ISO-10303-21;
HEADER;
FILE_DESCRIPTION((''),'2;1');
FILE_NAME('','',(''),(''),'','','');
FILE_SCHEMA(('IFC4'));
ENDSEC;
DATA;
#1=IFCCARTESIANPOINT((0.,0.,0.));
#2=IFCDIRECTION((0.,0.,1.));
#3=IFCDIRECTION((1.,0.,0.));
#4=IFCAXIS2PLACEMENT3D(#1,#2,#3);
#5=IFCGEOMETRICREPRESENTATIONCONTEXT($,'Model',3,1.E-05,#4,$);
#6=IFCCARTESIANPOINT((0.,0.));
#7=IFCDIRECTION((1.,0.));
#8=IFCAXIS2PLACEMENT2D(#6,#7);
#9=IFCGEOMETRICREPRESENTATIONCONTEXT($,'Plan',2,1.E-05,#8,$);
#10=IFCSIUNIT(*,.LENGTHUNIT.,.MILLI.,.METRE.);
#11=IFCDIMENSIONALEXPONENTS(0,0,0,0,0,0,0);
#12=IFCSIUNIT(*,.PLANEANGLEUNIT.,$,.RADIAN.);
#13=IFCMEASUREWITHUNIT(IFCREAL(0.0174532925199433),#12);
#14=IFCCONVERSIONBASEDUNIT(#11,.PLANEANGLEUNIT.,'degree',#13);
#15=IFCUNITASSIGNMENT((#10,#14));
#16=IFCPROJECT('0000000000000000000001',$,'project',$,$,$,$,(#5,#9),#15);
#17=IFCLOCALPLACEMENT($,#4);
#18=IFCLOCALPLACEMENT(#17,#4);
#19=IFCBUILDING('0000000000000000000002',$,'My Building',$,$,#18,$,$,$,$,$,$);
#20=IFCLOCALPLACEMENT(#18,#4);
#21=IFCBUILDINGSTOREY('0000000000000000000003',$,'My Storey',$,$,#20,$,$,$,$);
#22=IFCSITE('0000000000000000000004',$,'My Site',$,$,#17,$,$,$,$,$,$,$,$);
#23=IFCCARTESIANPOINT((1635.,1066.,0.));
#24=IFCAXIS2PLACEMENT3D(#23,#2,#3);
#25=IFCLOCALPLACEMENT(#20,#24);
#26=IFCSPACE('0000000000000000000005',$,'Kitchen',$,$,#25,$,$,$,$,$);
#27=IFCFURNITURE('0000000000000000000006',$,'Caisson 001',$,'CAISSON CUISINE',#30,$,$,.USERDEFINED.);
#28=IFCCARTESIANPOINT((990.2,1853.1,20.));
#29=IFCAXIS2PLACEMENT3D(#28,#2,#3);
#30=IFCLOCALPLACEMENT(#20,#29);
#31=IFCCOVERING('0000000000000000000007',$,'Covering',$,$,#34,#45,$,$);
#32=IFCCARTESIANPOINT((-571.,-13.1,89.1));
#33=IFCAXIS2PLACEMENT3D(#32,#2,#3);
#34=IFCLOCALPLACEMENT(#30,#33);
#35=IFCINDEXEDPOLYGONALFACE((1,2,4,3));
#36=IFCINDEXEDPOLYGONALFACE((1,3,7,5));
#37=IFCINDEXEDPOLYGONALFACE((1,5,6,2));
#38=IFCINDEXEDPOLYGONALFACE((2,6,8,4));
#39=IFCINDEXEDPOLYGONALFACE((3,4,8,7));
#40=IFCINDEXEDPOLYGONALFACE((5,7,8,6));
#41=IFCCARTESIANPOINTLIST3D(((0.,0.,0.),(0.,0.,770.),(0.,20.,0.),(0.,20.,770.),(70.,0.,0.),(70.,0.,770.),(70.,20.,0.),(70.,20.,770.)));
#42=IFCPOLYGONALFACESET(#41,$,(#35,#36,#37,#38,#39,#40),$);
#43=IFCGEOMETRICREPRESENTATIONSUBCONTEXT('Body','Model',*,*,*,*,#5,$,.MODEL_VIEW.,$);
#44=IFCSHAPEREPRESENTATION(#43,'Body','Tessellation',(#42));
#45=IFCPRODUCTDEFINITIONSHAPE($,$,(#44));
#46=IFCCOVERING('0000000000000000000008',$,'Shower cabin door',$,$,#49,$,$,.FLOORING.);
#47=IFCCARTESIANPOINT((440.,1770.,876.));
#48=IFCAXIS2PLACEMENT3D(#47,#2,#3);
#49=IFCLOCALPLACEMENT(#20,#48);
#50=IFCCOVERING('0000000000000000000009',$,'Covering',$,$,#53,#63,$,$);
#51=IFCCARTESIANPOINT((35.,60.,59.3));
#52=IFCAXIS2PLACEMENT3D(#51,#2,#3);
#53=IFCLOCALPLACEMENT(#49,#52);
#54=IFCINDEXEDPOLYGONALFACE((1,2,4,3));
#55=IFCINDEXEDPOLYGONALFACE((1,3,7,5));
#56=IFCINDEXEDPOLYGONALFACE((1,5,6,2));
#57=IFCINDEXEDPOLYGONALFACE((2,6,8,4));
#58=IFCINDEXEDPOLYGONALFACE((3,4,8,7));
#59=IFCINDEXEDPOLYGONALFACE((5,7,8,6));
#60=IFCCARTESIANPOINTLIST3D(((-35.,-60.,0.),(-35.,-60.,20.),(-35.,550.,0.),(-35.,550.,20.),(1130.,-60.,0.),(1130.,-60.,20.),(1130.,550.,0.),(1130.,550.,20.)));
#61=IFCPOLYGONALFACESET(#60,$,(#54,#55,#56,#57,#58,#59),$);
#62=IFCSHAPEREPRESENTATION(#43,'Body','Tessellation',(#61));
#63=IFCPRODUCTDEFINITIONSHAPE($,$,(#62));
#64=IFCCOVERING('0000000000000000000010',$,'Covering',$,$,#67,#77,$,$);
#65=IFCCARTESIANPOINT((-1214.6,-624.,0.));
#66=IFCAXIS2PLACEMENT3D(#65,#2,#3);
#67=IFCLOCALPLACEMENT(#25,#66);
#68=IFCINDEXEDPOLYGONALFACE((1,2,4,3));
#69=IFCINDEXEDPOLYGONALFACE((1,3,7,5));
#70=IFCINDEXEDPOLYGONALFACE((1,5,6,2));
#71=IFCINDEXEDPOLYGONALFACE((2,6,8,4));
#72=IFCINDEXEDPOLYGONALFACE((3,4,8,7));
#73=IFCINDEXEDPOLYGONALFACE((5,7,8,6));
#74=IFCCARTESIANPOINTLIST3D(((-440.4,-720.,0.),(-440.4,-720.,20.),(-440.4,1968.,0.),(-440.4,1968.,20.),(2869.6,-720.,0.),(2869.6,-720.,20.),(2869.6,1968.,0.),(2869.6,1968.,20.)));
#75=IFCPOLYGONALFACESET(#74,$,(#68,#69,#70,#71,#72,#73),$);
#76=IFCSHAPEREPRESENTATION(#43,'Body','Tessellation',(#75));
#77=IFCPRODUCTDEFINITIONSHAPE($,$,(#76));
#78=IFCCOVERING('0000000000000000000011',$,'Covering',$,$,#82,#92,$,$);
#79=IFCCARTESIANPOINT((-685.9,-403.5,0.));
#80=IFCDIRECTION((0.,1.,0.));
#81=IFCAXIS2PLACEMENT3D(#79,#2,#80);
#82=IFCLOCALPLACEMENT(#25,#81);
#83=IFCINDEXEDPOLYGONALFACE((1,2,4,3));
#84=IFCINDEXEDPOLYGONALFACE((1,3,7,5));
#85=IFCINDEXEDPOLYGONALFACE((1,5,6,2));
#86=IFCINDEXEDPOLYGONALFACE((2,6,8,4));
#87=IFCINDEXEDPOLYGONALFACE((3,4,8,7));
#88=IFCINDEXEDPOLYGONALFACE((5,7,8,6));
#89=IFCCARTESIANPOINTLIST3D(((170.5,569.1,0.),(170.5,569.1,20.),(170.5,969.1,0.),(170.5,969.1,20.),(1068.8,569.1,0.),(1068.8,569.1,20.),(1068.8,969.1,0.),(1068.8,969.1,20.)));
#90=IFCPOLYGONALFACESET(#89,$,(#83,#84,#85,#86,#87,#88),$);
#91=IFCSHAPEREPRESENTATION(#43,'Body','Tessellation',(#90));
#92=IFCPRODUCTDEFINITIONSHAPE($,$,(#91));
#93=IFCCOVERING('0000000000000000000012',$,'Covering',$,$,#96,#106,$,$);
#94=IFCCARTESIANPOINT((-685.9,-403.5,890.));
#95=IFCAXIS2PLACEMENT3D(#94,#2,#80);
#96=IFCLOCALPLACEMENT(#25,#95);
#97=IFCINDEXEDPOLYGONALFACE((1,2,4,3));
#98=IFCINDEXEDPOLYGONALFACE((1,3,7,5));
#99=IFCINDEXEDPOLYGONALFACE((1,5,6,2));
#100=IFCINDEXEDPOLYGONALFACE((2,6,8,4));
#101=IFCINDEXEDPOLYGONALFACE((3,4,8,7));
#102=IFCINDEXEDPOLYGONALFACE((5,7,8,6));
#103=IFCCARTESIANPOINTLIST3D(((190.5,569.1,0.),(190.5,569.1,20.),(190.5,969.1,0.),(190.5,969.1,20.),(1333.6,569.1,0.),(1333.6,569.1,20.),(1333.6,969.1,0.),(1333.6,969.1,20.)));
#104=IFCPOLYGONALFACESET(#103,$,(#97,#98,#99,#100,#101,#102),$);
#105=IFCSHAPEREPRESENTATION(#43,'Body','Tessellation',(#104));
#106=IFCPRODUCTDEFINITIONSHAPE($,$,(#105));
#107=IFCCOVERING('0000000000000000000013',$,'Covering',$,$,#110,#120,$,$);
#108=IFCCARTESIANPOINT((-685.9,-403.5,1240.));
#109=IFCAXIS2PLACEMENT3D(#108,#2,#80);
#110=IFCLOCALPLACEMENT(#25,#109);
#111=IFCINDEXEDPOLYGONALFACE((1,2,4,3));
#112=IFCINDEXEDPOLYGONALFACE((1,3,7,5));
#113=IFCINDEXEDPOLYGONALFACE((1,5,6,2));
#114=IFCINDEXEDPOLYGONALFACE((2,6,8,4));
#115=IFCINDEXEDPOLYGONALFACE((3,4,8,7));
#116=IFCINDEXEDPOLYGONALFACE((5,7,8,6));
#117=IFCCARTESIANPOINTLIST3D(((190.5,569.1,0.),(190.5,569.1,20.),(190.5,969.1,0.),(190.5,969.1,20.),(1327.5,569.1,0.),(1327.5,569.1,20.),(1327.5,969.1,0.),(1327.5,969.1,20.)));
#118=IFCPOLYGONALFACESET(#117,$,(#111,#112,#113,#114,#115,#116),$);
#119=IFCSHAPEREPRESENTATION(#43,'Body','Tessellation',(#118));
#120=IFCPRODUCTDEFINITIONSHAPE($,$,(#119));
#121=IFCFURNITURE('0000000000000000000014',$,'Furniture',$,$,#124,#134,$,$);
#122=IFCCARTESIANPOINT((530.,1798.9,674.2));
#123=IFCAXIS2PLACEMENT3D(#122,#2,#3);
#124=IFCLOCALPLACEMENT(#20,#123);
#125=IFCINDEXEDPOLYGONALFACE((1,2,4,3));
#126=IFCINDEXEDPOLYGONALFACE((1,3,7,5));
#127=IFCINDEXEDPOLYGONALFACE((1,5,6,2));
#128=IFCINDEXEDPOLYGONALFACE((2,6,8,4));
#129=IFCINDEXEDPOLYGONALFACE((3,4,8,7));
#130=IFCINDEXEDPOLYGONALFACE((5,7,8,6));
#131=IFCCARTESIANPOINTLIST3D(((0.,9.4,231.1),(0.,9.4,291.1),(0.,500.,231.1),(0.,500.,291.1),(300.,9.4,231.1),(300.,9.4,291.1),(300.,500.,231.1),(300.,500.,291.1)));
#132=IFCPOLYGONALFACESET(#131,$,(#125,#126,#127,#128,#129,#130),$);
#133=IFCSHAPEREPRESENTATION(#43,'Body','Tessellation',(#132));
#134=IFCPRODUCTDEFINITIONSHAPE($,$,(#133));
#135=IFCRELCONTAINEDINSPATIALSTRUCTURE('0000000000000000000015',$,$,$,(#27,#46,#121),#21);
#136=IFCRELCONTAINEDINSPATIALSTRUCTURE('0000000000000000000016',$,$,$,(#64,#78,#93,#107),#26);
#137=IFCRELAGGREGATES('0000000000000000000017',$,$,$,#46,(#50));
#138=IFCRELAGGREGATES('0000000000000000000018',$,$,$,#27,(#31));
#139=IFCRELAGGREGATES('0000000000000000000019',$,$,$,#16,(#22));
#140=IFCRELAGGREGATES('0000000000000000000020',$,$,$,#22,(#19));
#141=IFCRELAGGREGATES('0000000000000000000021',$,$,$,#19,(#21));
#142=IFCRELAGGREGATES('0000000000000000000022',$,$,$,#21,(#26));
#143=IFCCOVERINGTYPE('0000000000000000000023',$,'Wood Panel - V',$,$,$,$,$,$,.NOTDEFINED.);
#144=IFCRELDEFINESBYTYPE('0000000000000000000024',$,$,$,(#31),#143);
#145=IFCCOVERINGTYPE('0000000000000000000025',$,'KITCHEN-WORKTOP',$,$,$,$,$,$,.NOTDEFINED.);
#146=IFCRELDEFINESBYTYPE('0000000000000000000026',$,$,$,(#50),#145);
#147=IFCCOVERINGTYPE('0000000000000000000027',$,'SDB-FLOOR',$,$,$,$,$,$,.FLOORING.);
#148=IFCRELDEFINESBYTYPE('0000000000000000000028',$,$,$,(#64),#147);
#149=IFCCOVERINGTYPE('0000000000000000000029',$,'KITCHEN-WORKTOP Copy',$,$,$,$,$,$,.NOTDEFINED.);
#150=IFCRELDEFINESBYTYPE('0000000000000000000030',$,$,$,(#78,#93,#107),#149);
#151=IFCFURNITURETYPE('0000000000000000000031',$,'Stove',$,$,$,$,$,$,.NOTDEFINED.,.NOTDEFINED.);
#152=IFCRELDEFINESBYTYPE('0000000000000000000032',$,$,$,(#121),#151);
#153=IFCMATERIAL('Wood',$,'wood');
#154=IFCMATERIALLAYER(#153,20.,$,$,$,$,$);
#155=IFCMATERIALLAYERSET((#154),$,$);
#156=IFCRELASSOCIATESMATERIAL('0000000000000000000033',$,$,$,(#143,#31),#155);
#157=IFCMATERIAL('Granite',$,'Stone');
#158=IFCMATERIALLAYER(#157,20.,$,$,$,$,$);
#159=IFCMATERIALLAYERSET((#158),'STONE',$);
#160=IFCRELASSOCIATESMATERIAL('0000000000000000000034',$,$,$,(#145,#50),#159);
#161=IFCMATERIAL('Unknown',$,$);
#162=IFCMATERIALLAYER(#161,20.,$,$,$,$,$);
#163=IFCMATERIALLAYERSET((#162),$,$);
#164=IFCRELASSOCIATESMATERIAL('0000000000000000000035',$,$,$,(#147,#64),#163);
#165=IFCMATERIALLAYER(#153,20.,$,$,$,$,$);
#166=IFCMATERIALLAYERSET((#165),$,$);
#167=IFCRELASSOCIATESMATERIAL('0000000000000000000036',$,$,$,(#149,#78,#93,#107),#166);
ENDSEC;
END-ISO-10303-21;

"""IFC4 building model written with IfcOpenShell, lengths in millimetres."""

from ifc_helpers import new_model, entity, si_unit, converted_unit, frame, origin_with_axes, origin_2d_with_axis, place, context, subcontext, project, spatial, line, indexed_curve, outline, extrude, source, transform, mapped, material, layer, layer_set, layer_usage, type_object, type_shapes, element, aggregate, save


model = new_model("IFC4")

# Units and contexts
model_context = context("Model", 3, precision=1e-05, world=origin_with_axes())
plan_context = context("Plan", 2, precision=1e-05, world=origin_2d_with_axis())
body_context = subcontext(model_context, "Body", "Model", "MODEL_VIEW")
ifc_project = project(units=[si_unit("LENGTHUNIT", "METRE", prefix="MILLI"), converted_unit("PLANEANGLEUNIT", "degree", entity("IfcReal", 0.0174532925199433), si_unit("PLANEANGLEUNIT", "RADIAN"), dimensions=[0, 0, 0, 0, 0, 0, 0])], contexts=[model_context, plan_context])

# Site, building, storey, space
site_placement = place(None, origin_with_axes())
site = spatial("IfcSite", under=ifc_project, at=site_placement, Name="My Site")
building_placement = place(site_placement, origin_with_axes())
building = spatial("IfcBuilding", under=site, at=building_placement, Name="My Building")
storey_placement = place(building_placement, origin_with_axes())
storey = spatial("IfcBuildingStorey", under=building, at=storey_placement, Name="My Storey")
space_1_placement = place(storey_placement, frame((1635.0, 1066.0, 0.0), z_axis=(0.0, 0.0, 1.0), x_axis=(1.0, 0.0, 0.0)))
space_1 = spatial("IfcSpace", under=storey, at=space_1_placement, Name="Kitchen")

# Shared definitions
ifc_material_1 = material(Name="Unknown")

# Furniture
furniture_1_placement = place(storey_placement, frame((990.2, 1853.1, 20.0), z_axis=(0.0, 0.0, 1.0), x_axis=(1.0, 0.0, 0.0)))
furniture_1 = element("IfcFurniture", 1, at=furniture_1_placement, inside=storey, Name="Caisson 001", ObjectType="CAISSON CUISINE", PredefinedType="USERDEFINED")

# Shared definitions
ifc_material_2 = material(Name="Wood", Category="wood")
ifc_layer_1 = layer(ifc_material_2, 20.0)
ifc_layer_set_1 = layer_set([ifc_layer_1])
covering_type_1 = type_object("IfcCoveringType", Name="Wood Panel - V", PredefinedType="NOTDEFINED", material=ifc_layer_set_1)

# Covering
ifc_layer_usage_1 = layer_usage(ifc_layer_set_1, "AXIS2", "POSITIVE", 0.0)
covering_1_placement = place(furniture_1_placement, frame((-571.0, -13.1, 89.1), z_axis=(0.0, 0.0, 1.0), x_axis=(1.0, 0.0, 0.0)))
covering_1 = element("IfcCovering", 2, at=covering_1_placement, type_object=covering_type_1, material=ifc_layer_usage_1, Name="Covering", context=body_context, shape_type="SweptSolid", body=[
    extrude(outline(indexed_curve([(0.0, 0.0), (0.0, 20.0), (70.0, 20.0), (70.0, 0.0), (0.0, 0.0)], self_intersect=False)), origin_with_axes(), (0.0, 0.0, 1.0), 770.0),
])

# Coverings
covering_2_placement = place(storey_placement, frame((440.0, 1770.0, 876.0), z_axis=(0.0, 0.0, 1.0), x_axis=(1.0, 0.0, 0.0)))
covering_2 = element("IfcCovering", 3, at=covering_2_placement, inside=storey, Name="Shower cabin door", PredefinedType="FLOORING")
ifc_material_3 = material(Name="Granite", Category="Stone")
ifc_layer_2 = layer(ifc_material_3, 20.0)
ifc_layer_set_2 = layer_set([ifc_layer_2], Name="STONE")
ifc_layer_usage_2 = layer_usage(ifc_layer_set_2, "AXIS3", "POSITIVE", 0.0)
covering_type_2 = type_object("IfcCoveringType", Name="KITCHEN-WORKTOP", PredefinedType="NOTDEFINED", material=ifc_layer_set_2)
covering_3_placement = place(covering_2_placement, frame((35.0, 60.0, 59.3), z_axis=(0.0, 0.0, 1.0), x_axis=(1.0, 0.0, 0.0)))
covering_3 = element("IfcCovering", 4, at=covering_3_placement, type_object=covering_type_2, material=ifc_layer_usage_2, Name="Covering", context=body_context, shape_type="SweptSolid", body=[
    extrude(outline(indexed_curve([(1130.0, -60.0), (-35.0, -60.0), (-35.0, 550.0), (1130.0, 550.0), (1130.0, -60.0)])), None, (0.0, 0.0, 1.0), 20.0),
])
aggregate(covering_2, [covering_3])

aggregate(furniture_1, [covering_1])

# Covering
ifc_layer_3 = layer(ifc_material_1, 20.0)
ifc_layer_set_3 = layer_set([ifc_layer_3])
ifc_layer_usage_3 = layer_usage(ifc_layer_set_3, "AXIS3", "POSITIVE", 0.0)
covering_type_3 = type_object("IfcCoveringType", Name="SDB-FLOOR", PredefinedType="FLOORING", material=ifc_layer_set_3)
covering_4_placement = place(space_1_placement, frame((-1214.6, -624.0, 0.0), z_axis=(0.0, 0.0, 1.0), x_axis=(1.0, 0.0, 0.0)))
element("IfcCovering", 5, at=covering_4_placement, inside=space_1, type_object=covering_type_3, material=ifc_layer_usage_3, Name="Covering", context=body_context, shape_type="SweptSolid", body=[
    extrude(outline(indexed_curve([(2869.6, 1968.0), (-440.4, 1968.0), (-440.4, -720.0), (2869.6, -720.0)], segments=[line(3, 2), line(2, 1), line(1, 4), line(4, 3)], self_intersect=False)), None, (0.0, 0.0, 1.0), 20.0),
])

# Coverings
ifc_layer_4 = layer(ifc_material_2, 20.0)
ifc_layer_set_4 = layer_set([ifc_layer_4])
ifc_layer_usage_4 = layer_usage(ifc_layer_set_4, "AXIS3", "POSITIVE", 0.0)
covering_type_4 = type_object("IfcCoveringType", Name="KITCHEN-WORKTOP Copy", PredefinedType="NOTDEFINED", material=ifc_layer_set_4)
covering_5_placement = place(space_1_placement, frame((-685.9, -403.5, 0.0), z_axis=(0.0, 0.0, 1.0), x_axis=(0.0, 1.0, 0.0)))
element("IfcCovering", 6, at=covering_5_placement, inside=space_1, type_object=covering_type_4, material=ifc_layer_usage_4, Name="Covering", context=body_context, shape_type="SweptSolid", body=[
    extrude(outline(indexed_curve([(170.5, 569.1), (170.5, 969.1), (1068.8, 969.1), (1068.8, 569.1)], segments=[line(4, 1), line(1, 2), line(2, 3), line(3, 4)], self_intersect=False)), None, (0.0, 0.0, 1.0), 20.0),
])
ifc_layer_usage_5 = layer_usage(ifc_layer_set_4, "AXIS3", "POSITIVE", 0.0)
covering_6_placement = place(space_1_placement, frame((-685.9, -403.5, 890.0), z_axis=(0.0, 0.0, 1.0), x_axis=(0.0, 1.0, 0.0)))
element("IfcCovering", 7, at=covering_6_placement, inside=space_1, type_object=covering_type_4, material=ifc_layer_usage_5, Name="Covering", context=body_context, shape_type="SweptSolid", body=[
    extrude(outline(indexed_curve([(190.5, 569.1), (190.5, 969.1), (1333.6, 969.1), (1333.6, 569.1), (190.5, 569.1)])), None, (0.0, 0.0, 1.0), 20.0),
])
ifc_layer_usage_6 = layer_usage(ifc_layer_set_4, "AXIS3", "POSITIVE", 0.0)
covering_7_placement = place(space_1_placement, frame((-685.9, -403.5, 1240.0), z_axis=(0.0, 0.0, 1.0), x_axis=(0.0, 1.0, 0.0)))
element("IfcCovering", 8, at=covering_7_placement, inside=space_1, type_object=covering_type_4, material=ifc_layer_usage_6, Name="Covering", context=body_context, shape_type="SweptSolid", body=[
    extrude(outline(indexed_curve([(190.5, 569.1), (190.5, 969.1), (1327.5, 969.1), (1327.5, 569.1), (190.5, 569.1)])), None, (0.0, 0.0, 1.0), 20.0),
])

# Furniture
furniture_type = type_object("IfcFurnitureType", Name="Stove", AssemblyPlace="NOTDEFINED", PredefinedType="NOTDEFINED")
shared_shape_1 = source(origin_with_axes(), body_context, "Body", "SolidModel", [
    extrude(outline(indexed_curve([(0.0, 9.4), (300.0, 9.4), (300.0, 500.0), (0.0, 500.0), (0.0, 9.4)])), frame((0.0, 0.0, 231.1), z_axis=(0.0, 0.0, 1.0), x_axis=(1.0, 0.0, 0.0)), (0.0, 0.0, 1.0), 60.0),
])
type_shapes(furniture_type, [shared_shape_1])
furniture_2_placement = place(storey_placement, frame((530.0, 1798.9, 674.2), z_axis=(0.0, 0.0, 1.0), x_axis=(1.0, 0.0, 0.0)))
element("IfcFurniture", 9, at=furniture_2_placement, inside=storey, type_object=furniture_type, Name="Furniture", context=body_context, shape_type="MappedRepresentation", body=[
    mapped(shared_shape_1, transform((0.0, 0.0, 0.0), x_axis=(1.0, 0.0, 0.0), y_axis=(0.0, 1.0, 0.0), z_axis=(0.0, 0.0, 1.0), scale=1.0)),
])

save(model, "model.ifc")
